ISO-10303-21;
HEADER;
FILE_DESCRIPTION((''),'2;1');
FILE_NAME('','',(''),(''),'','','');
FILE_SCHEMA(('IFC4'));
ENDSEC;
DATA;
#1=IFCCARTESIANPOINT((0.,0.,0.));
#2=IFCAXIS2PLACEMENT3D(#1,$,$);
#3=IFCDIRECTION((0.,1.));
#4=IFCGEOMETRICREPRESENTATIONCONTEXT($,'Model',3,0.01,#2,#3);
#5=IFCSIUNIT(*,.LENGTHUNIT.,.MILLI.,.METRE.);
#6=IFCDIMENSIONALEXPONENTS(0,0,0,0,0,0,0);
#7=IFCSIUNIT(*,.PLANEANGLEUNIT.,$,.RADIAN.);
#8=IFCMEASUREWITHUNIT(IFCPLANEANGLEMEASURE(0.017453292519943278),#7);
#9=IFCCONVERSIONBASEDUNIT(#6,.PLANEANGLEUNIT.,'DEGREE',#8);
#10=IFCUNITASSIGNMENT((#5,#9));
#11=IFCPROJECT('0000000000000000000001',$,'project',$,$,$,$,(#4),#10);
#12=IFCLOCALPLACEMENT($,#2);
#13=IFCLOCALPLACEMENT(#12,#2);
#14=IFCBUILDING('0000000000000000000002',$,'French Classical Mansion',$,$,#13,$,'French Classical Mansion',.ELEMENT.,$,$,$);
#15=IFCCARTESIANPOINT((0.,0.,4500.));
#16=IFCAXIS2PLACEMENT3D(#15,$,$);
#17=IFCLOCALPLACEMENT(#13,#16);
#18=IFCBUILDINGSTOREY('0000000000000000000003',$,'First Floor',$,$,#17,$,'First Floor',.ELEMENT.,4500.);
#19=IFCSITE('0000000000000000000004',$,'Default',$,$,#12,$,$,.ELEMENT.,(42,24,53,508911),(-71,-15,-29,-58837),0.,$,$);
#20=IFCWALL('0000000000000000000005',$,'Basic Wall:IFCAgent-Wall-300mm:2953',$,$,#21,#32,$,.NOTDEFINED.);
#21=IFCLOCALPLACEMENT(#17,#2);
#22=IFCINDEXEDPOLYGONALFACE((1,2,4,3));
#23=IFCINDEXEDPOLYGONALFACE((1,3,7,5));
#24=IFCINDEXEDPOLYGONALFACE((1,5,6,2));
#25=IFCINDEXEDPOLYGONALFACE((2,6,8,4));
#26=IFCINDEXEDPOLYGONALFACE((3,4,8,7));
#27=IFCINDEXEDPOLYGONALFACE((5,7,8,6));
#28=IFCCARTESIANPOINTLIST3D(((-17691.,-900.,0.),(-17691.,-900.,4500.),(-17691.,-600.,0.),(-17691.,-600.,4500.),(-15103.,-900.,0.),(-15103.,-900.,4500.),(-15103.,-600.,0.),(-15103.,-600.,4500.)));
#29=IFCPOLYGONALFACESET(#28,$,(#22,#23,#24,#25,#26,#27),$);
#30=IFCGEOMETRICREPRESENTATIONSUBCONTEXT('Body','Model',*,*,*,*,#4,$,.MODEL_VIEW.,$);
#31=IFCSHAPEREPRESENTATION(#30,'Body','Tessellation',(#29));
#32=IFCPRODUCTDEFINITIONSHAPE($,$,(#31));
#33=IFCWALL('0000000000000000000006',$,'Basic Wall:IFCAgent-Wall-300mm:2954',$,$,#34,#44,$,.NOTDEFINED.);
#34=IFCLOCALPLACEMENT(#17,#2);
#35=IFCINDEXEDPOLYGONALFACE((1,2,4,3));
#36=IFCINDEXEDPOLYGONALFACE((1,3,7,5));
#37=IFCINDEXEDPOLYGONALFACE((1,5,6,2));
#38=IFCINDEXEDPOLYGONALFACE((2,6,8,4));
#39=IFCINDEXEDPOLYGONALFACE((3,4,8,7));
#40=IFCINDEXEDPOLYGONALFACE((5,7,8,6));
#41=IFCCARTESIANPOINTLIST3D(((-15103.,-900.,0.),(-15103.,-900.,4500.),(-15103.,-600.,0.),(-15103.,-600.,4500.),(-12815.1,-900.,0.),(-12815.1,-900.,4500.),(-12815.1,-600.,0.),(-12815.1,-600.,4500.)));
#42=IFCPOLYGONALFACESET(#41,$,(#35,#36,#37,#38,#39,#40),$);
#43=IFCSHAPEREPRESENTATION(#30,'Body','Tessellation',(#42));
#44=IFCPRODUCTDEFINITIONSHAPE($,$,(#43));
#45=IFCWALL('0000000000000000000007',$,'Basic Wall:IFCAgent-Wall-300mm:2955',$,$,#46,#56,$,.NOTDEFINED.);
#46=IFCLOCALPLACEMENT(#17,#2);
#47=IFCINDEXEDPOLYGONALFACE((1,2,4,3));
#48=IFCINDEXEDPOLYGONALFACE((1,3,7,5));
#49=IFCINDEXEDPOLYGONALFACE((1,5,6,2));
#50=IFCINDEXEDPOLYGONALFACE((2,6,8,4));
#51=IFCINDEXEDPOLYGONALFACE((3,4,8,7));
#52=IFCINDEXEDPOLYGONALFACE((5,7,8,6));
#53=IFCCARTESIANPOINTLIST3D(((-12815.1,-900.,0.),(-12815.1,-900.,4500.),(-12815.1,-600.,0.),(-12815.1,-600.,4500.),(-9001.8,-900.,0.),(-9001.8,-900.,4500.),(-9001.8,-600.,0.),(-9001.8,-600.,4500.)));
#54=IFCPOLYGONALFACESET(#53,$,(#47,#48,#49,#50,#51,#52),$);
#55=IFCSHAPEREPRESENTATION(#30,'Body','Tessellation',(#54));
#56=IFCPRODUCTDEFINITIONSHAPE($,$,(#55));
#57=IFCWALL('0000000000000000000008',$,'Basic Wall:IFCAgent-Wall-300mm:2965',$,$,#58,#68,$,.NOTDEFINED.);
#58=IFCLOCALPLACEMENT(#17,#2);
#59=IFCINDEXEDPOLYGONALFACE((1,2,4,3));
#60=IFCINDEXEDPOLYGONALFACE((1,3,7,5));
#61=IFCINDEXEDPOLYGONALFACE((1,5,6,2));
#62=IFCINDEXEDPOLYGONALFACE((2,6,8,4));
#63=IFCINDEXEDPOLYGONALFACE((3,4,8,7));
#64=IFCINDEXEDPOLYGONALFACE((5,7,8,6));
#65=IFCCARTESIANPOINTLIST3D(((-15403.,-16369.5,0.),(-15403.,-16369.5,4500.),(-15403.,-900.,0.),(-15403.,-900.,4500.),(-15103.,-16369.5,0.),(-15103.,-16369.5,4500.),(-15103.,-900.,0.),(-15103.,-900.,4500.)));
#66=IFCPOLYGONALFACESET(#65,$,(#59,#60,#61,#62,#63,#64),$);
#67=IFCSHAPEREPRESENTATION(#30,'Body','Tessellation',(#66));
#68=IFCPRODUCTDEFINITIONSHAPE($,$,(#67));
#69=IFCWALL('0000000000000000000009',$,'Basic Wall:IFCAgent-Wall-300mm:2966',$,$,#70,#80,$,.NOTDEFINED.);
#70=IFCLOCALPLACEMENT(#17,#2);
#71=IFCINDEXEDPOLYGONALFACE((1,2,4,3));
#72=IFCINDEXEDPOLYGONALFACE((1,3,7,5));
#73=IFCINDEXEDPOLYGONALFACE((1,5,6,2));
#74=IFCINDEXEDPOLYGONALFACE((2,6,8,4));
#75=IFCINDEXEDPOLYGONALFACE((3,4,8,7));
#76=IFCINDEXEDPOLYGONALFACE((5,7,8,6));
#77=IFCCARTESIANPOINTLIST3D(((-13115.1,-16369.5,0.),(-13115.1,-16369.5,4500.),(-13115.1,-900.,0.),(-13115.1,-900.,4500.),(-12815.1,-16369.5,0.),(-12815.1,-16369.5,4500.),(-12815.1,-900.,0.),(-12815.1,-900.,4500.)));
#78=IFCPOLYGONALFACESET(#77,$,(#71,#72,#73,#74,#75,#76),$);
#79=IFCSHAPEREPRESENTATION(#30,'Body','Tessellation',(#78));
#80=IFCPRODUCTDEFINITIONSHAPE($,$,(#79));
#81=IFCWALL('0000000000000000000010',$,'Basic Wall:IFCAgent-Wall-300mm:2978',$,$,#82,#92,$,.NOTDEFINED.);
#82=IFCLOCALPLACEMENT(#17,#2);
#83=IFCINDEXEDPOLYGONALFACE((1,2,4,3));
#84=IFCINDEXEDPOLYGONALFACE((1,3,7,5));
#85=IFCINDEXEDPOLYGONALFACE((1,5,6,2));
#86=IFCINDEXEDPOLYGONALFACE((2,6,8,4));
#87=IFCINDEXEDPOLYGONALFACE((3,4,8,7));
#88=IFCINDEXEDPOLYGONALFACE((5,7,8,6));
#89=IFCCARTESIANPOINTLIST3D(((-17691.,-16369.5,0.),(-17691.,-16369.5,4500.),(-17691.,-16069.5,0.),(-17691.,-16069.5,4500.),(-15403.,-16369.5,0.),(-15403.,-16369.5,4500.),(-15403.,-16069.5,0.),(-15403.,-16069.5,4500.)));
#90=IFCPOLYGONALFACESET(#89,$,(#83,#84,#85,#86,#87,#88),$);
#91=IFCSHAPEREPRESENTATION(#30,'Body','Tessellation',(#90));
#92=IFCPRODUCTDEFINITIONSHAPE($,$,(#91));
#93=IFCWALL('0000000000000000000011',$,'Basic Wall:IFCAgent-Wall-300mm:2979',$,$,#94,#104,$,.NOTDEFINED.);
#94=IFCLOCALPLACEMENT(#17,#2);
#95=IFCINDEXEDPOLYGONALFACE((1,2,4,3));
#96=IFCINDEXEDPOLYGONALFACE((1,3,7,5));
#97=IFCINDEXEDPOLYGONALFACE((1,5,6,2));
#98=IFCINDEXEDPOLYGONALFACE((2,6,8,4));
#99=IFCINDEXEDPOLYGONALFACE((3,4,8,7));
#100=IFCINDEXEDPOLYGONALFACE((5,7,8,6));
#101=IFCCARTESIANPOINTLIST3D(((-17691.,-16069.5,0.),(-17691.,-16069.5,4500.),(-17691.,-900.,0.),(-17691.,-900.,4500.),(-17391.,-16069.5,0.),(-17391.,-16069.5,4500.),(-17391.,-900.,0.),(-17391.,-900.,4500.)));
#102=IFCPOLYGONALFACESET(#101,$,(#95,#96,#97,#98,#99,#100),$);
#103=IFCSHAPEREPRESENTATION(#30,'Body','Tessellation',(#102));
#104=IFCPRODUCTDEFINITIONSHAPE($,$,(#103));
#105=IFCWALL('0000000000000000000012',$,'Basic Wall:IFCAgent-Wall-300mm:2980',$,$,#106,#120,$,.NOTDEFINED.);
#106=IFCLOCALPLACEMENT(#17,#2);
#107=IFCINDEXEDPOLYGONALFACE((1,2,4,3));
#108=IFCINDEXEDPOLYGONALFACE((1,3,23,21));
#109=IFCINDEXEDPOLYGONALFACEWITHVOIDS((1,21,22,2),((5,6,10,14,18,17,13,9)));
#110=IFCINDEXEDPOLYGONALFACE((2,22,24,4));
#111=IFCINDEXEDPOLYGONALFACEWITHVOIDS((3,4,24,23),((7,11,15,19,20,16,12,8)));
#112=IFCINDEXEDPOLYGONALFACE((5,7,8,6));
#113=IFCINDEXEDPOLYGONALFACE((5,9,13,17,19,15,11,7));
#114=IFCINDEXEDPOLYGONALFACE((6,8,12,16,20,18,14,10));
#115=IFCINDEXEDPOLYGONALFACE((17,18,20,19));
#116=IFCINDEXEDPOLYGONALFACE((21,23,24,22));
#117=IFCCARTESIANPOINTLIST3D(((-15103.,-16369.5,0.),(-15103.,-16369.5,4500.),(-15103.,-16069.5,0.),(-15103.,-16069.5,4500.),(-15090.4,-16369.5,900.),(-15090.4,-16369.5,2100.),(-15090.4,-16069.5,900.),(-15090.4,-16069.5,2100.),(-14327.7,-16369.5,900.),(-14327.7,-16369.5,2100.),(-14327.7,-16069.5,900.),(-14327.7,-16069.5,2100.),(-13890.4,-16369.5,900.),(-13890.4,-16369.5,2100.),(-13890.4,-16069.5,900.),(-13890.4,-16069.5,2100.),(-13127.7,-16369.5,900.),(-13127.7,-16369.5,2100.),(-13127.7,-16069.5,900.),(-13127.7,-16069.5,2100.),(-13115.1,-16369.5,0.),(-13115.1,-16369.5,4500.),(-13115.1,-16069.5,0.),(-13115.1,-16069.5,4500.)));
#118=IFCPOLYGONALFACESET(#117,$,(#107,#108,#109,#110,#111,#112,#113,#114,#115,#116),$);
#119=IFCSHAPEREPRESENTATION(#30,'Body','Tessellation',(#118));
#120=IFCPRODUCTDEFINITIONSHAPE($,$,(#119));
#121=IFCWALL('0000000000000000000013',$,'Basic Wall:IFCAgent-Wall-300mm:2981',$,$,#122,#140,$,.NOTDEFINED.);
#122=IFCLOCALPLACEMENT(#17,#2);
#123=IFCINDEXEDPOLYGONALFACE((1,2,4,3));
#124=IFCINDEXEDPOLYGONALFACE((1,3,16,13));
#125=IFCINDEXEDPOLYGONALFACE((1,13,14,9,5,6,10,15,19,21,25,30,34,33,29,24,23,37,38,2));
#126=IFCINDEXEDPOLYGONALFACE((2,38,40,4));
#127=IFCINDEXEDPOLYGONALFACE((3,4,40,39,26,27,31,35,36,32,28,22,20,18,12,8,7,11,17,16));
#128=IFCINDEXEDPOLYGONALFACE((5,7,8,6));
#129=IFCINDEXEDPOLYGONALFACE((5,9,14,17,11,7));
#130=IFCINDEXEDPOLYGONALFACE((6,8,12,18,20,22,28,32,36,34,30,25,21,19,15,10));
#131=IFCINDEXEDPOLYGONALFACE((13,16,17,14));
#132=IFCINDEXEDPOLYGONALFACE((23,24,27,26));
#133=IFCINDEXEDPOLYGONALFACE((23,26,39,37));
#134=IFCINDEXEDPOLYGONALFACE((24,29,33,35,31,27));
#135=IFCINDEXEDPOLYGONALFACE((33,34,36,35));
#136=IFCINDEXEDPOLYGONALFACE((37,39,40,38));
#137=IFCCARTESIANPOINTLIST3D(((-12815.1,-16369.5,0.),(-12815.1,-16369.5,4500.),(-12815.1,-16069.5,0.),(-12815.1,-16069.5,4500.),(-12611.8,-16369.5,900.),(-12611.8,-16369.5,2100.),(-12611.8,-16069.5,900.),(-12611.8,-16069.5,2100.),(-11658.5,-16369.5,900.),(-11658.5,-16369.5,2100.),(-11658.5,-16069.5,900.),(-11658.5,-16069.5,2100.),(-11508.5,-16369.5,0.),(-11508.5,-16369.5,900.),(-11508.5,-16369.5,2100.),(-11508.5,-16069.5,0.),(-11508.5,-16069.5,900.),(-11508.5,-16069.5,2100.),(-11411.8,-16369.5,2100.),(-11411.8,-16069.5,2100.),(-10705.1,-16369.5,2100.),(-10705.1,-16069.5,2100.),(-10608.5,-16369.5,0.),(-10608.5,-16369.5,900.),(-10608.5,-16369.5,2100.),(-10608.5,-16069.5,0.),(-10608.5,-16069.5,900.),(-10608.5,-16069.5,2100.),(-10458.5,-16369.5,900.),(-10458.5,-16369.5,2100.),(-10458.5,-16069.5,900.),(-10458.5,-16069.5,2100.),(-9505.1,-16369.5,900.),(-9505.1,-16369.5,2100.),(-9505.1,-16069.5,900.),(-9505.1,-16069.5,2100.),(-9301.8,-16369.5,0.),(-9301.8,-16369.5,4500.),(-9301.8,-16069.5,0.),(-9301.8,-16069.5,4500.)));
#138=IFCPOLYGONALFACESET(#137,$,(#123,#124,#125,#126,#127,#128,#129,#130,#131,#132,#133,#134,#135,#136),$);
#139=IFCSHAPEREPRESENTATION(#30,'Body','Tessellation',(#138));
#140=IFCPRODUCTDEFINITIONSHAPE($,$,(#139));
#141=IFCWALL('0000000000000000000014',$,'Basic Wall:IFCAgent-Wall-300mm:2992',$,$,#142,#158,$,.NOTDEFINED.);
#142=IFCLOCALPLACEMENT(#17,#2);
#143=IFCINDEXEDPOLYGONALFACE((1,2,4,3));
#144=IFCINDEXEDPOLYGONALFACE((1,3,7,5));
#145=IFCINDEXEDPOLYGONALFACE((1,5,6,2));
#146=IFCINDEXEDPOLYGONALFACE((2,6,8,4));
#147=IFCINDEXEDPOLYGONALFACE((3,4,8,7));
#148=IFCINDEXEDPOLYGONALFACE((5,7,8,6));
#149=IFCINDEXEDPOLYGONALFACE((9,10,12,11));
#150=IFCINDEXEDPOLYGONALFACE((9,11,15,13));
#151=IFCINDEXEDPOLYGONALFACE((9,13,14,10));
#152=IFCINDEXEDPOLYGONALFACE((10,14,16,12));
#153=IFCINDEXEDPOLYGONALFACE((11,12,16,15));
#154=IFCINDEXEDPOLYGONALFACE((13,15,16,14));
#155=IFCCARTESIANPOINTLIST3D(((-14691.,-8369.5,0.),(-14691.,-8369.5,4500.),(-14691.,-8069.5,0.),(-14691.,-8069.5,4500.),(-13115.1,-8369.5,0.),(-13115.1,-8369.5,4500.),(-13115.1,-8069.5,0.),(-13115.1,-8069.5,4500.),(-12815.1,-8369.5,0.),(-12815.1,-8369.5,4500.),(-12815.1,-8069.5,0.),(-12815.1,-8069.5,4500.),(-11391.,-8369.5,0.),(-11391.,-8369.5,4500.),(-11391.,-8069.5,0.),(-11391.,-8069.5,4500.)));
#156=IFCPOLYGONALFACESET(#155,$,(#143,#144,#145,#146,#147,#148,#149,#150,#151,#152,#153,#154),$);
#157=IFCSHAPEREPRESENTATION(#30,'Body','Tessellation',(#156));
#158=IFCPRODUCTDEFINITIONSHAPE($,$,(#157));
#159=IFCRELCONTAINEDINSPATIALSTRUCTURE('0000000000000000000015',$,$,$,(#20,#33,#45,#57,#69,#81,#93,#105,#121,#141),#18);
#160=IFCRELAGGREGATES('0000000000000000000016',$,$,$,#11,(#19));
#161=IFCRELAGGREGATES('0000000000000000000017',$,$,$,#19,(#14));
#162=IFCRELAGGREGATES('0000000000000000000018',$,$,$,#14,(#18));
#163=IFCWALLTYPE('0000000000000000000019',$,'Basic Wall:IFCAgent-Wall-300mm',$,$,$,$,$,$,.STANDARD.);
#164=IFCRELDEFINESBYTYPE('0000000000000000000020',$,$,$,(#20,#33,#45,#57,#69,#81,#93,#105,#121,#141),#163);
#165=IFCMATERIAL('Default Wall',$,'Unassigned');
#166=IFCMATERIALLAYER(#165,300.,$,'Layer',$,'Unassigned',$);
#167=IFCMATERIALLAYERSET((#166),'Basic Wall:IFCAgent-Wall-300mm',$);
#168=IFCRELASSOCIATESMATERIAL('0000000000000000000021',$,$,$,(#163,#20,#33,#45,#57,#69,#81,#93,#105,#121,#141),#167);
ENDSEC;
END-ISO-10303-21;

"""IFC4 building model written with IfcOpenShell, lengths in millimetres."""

from ifc_helpers import new_model, entity, si_unit, converted_unit, direction, frame, frame_2d, origin, place, context, subcontext, project, spatial, rectangle, extrude, material, layer, layer_set, layer_usage, type_object, element, save


model = new_model("IFC4")

# Units and contexts
model_context = context("Model", 3, precision=0.01, world=origin(), true_north=direction((0.0, 1.0)))
body_context = subcontext(model_context, "Body", "Model", "MODEL_VIEW")
ifc_project = project(units=[si_unit("LENGTHUNIT", "METRE", prefix="MILLI"), converted_unit("PLANEANGLEUNIT", "DEGREE", entity("IfcPlaneAngleMeasure", 0.017453292519943278), si_unit("PLANEANGLEUNIT", "RADIAN"), dimensions=[0, 0, 0, 0, 0, 0, 0])], contexts=[model_context])

# Site, building, storey
site_placement = place(None, origin())
site = spatial("IfcSite", under=ifc_project, at=site_placement, Name="Default", CompositionType="ELEMENT", RefLatitude=(42, 24, 53, 508911), RefLongitude=(-71, -15, -29, -58837), RefElevation=0.0)
building_placement = place(site_placement, origin())
building = spatial("IfcBuilding", under=site, at=building_placement, Name="French Classical Mansion", LongName="French Classical Mansion", CompositionType="ELEMENT")
storey_placement = place(building_placement, frame((0.0, 0.0, 4500.0)))
storey = spatial("IfcBuildingStorey", under=building, at=storey_placement, Name="First Floor", LongName="First Floor", CompositionType="ELEMENT", Elevation=4500.0)

# Walls
ifc_material = material(Name="Default Wall", Category="Unassigned")
ifc_layer = layer(ifc_material, 300.0, Name="Layer", Category="Unassigned")
ifc_layer_set = layer_set([ifc_layer], Name="Basic Wall:IFCAgent-Wall-300mm")
ifc_layer_usage_1 = layer_usage(ifc_layer_set, "AXIS2", "NEGATIVE", 150.0)
wall_type = type_object("IfcWallType", Name="Basic Wall:IFCAgent-Wall-300mm", PredefinedType="STANDARD", material=ifc_layer_set)
wall_1_placement = place(storey_placement, frame((-17691.0, -750.0, 0.0)))
element("IfcWall", 1, at=wall_1_placement, inside=storey, type_object=wall_type, material=ifc_layer_usage_1, Name="Basic Wall:IFCAgent-Wall-300mm:2953", PredefinedType="NOTDEFINED", context=body_context, shape_type="SweptSolid", body=[
    extrude(rectangle(XDim=2588.0, YDim=300.0, at=frame_2d((1294.0, 0.0), x_axis=(-1.0, 0.0))), origin(), (0.0, 0.0, 1.0), 4500.0),
])
ifc_layer_usage_2 = layer_usage(ifc_layer_set, "AXIS2", "NEGATIVE", 150.0)
wall_2_placement = place(storey_placement, frame((-15103.0, -750.0, 0.0)))
element("IfcWall", 2, at=wall_2_placement, inside=storey, type_object=wall_type, material=ifc_layer_usage_2, Name="Basic Wall:IFCAgent-Wall-300mm:2954", PredefinedType="NOTDEFINED", context=body_context, shape_type="SweptSolid", body=[
    extrude(rectangle(XDim=2288.0, YDim=300.0, at=frame_2d((1144.0, 0.0), x_axis=(-1.0, 0.0))), origin(), (0.0, 0.0, 1.0), 4500.0),
])
ifc_layer_usage_3 = layer_usage(ifc_layer_set, "AXIS2", "NEGATIVE", 150.0)
wall_3_placement = place(storey_placement, frame((-12815.1, -750.0, 0.0)))
element("IfcWall", 3, at=wall_3_placement, inside=storey, type_object=wall_type, material=ifc_layer_usage_3, Name="Basic Wall:IFCAgent-Wall-300mm:2955", PredefinedType="NOTDEFINED", context=body_context, shape_type="SweptSolid", body=[
    extrude(rectangle(XDim=3813.3, YDim=300.0, at=frame_2d((1906.6, 0.0), x_axis=(-1.0, 0.0))), origin(), (0.0, 0.0, 1.0), 4500.0),
])
ifc_layer_usage_4 = layer_usage(ifc_layer_set, "AXIS2", "NEGATIVE", 150.0)
wall_4_placement = place(storey_placement, frame((-15253.0, -16369.5, 0.0), z_axis=(0.0, 0.0, 1.0), x_axis=(0.0, 1.0, 0.0)))
element("IfcWall", 4, at=wall_4_placement, inside=storey, type_object=wall_type, material=ifc_layer_usage_4, Name="Basic Wall:IFCAgent-Wall-300mm:2965", PredefinedType="NOTDEFINED", context=body_context, shape_type="SweptSolid", body=[
    extrude(rectangle(XDim=15469.5, YDim=300.0, at=frame_2d((7734.8, 0.0), x_axis=(-1.0, 0.0))), origin(), (0.0, 0.0, 1.0), 4500.0),
])
ifc_layer_usage_5 = layer_usage(ifc_layer_set, "AXIS2", "NEGATIVE", 150.0)
wall_5_placement = place(storey_placement, frame((-12965.1, -16369.5, 0.0), z_axis=(0.0, 0.0, 1.0), x_axis=(0.0, 1.0, 0.0)))
element("IfcWall", 5, at=wall_5_placement, inside=storey, type_object=wall_type, material=ifc_layer_usage_5, Name="Basic Wall:IFCAgent-Wall-300mm:2966", PredefinedType="NOTDEFINED", context=body_context, shape_type="SweptSolid", body=[
    extrude(rectangle(XDim=15469.5, YDim=300.0, at=frame_2d((7734.8, 0.0), x_axis=(-1.0, 0.0))), origin(), (0.0, 0.0, 1.0), 4500.0),
])
ifc_layer_usage_6 = layer_usage(ifc_layer_set, "AXIS2", "NEGATIVE", 150.0)
wall_6_placement = place(storey_placement, frame((-17691.0, -16219.5, 0.0)))
element("IfcWall", 6, at=wall_6_placement, inside=storey, type_object=wall_type, material=ifc_layer_usage_6, Name="Basic Wall:IFCAgent-Wall-300mm:2978", PredefinedType="NOTDEFINED", context=body_context, shape_type="SweptSolid", body=[
    extrude(rectangle(XDim=2288.0, YDim=300.0, at=frame_2d((1144.0, 0.0), x_axis=(-1.0, 0.0))), origin(), (0.0, 0.0, 1.0), 4500.0),
])
ifc_layer_usage_7 = layer_usage(ifc_layer_set, "AXIS2", "NEGATIVE", 150.0)
wall_7_placement = place(storey_placement, frame((-17541.0, -16069.5, 0.0), z_axis=(0.0, 0.0, 1.0), x_axis=(0.0, 1.0, 0.0)))
element("IfcWall", 7, at=wall_7_placement, inside=storey, type_object=wall_type, material=ifc_layer_usage_7, Name="Basic Wall:IFCAgent-Wall-300mm:2979", PredefinedType="NOTDEFINED", context=body_context, shape_type="SweptSolid", body=[
    extrude(rectangle(XDim=15169.5, YDim=300.0, at=frame_2d((7584.8, 0.0), x_axis=(-1.0, 0.0))), origin(), (0.0, 0.0, 1.0), 4500.0),
])

# Walls, openings
ifc_layer_usage_8 = layer_usage(ifc_layer_set, "AXIS2", "NEGATIVE", 150.0)
wall_8_placement = place(storey_placement, frame((-15103.0, -16219.5, 0.0)))
wall_8 = element("IfcWall", 8, at=wall_8_placement, inside=storey, type_object=wall_type, material=ifc_layer_usage_8, Name="Basic Wall:IFCAgent-Wall-300mm:2980", PredefinedType="NOTDEFINED", context=body_context, shape_type="SweptSolid", body=[
    extrude(rectangle(XDim=1988.0, YDim=300.0, at=frame_2d((994.0, 0.0), x_axis=(-1.0, 0.0))), origin(), (0.0, 0.0, 1.0), 4500.0),
])
opening_1_placement = place(wall_8_placement, origin())
element("IfcOpeningElement", 9, at=opening_1_placement, cuts=wall_8, PredefinedType="OPENING", context=body_context, shape_type="SweptSolid", body=[
    extrude(rectangle(XDim=1200.0, YDim=1200.0, at=frame_2d((0.0, 0.0), x_axis=(1.0, 0.0))), frame((612.7, -150.0, 1500.0), z_axis=(0.0, 1.0, 0.0), x_axis=(0.0, 0.0, -1.0)), (0.0, 0.0, 1.0), 300.0),
])
opening_2_placement = place(wall_8_placement, origin())
element("IfcOpeningElement", 10, at=opening_2_placement, cuts=wall_8, PredefinedType="OPENING", context=body_context, shape_type="SweptSolid", body=[
    extrude(rectangle(XDim=1200.0, YDim=1200.0, at=frame_2d((0.0, 0.0), x_axis=(1.0, 0.0))), frame((1375.3, -150.0, 1500.0), z_axis=(0.0, 1.0, 0.0), x_axis=(0.0, 0.0, -1.0)), (0.0, 0.0, 1.0), 300.0),
])
ifc_layer_usage_9 = layer_usage(ifc_layer_set, "AXIS2", "NEGATIVE", 150.0)
wall_9_placement = place(storey_placement, frame((-12815.1, -16219.5, 0.0)))
wall_9 = element("IfcWall", 11, at=wall_9_placement, inside=storey, type_object=wall_type, material=ifc_layer_usage_9, Name="Basic Wall:IFCAgent-Wall-300mm:2981", PredefinedType="NOTDEFINED", context=body_context, shape_type="SweptSolid", body=[
    extrude(rectangle(XDim=3513.3, YDim=300.0, at=frame_2d((1756.6, 0.0), x_axis=(-1.0, 0.0))), origin(), (0.0, 0.0, 1.0), 4500.0),
])
opening_3_placement = place(wall_9_placement, origin())
element("IfcOpeningElement", 12, at=opening_3_placement, cuts=wall_9, PredefinedType="OPENING", context=body_context, shape_type="SweptSolid", body=[
    extrude(rectangle(XDim=2100.0, YDim=900.0, at=frame_2d((0.0, 0.0), x_axis=(1.0, 0.0))), frame((1756.6, -150.0, 1050.0), z_axis=(0.0, 1.0, 0.0), x_axis=(0.0, 0.0, -1.0)), (0.0, 0.0, 1.0), 300.0),
])
opening_4_placement = place(wall_9_placement, origin())
element("IfcOpeningElement", 13, at=opening_4_placement, cuts=wall_9, PredefinedType="OPENING", context=body_context, shape_type="SweptSolid", body=[
    extrude(rectangle(XDim=1200.0, YDim=1200.0, at=frame_2d((0.0, 0.0), x_axis=(1.0, 0.0))), frame((803.3, -150.0, 1500.0), z_axis=(0.0, 1.0, 0.0), x_axis=(0.0, 0.0, -1.0)), (0.0, 0.0, 1.0), 300.0),
])
opening_5_placement = place(wall_9_placement, origin())
element("IfcOpeningElement", 14, at=opening_5_placement, cuts=wall_9, PredefinedType="OPENING", context=body_context, shape_type="SweptSolid", body=[
    extrude(rectangle(XDim=1200.0, YDim=1200.0, at=frame_2d((0.0, 0.0), x_axis=(1.0, 0.0))), frame((1756.6, -150.0, 1500.0), z_axis=(0.0, 1.0, 0.0), x_axis=(0.0, 0.0, -1.0)), (0.0, 0.0, 1.0), 300.0),
])
opening_6_placement = place(wall_9_placement, origin())
element("IfcOpeningElement", 15, at=opening_6_placement, cuts=wall_9, PredefinedType="OPENING", context=body_context, shape_type="SweptSolid", body=[
    extrude(rectangle(XDim=1200.0, YDim=1200.0, at=frame_2d((0.0, 0.0), x_axis=(1.0, 0.0))), frame((2709.9, -150.0, 1500.0), z_axis=(0.0, 1.0, 0.0), x_axis=(0.0, 0.0, -1.0)), (0.0, 0.0, 1.0), 300.0),
])

# Wall, opening
ifc_layer_usage_10 = layer_usage(ifc_layer_set, "AXIS2", "NEGATIVE", 150.0)
wall_10_placement = place(storey_placement, frame((-14691.0, -8219.5, 0.0)))
wall_10 = element("IfcWall", 16, at=wall_10_placement, inside=storey, type_object=wall_type, material=ifc_layer_usage_10, Name="Basic Wall:IFCAgent-Wall-300mm:2992", PredefinedType="NOTDEFINED", context=body_context, shape_type="SweptSolid", body=[
    extrude(rectangle(XDim=3300.0, YDim=300.0, at=frame_2d((1650.0, 0.0), x_axis=(-1.0, 0.0))), origin(), (0.0, 0.0, 1.0), 4500.0),
])
opening_7_placement = place(storey_placement, frame((-14691.0, -8219.5, 0.0)))
element("IfcOpeningElement", 17, at=opening_7_placement, cuts=wall_10, PredefinedType="OPENING", context=body_context, shape_type="SweptSolid", body=[
    extrude(rectangle(XDim=4500.0, YDim=300.0, at=frame_2d((0.0, 0.0), x_axis=(1.0, 0.0))), frame((1575.9, 0.0, 2250.0), z_axis=(1.0, 0.0, 0.0), x_axis=(0.0, 0.0, -1.0)), (0.0, 0.0, 1.0), 300.0),
])

save(model, "model.ifc")
